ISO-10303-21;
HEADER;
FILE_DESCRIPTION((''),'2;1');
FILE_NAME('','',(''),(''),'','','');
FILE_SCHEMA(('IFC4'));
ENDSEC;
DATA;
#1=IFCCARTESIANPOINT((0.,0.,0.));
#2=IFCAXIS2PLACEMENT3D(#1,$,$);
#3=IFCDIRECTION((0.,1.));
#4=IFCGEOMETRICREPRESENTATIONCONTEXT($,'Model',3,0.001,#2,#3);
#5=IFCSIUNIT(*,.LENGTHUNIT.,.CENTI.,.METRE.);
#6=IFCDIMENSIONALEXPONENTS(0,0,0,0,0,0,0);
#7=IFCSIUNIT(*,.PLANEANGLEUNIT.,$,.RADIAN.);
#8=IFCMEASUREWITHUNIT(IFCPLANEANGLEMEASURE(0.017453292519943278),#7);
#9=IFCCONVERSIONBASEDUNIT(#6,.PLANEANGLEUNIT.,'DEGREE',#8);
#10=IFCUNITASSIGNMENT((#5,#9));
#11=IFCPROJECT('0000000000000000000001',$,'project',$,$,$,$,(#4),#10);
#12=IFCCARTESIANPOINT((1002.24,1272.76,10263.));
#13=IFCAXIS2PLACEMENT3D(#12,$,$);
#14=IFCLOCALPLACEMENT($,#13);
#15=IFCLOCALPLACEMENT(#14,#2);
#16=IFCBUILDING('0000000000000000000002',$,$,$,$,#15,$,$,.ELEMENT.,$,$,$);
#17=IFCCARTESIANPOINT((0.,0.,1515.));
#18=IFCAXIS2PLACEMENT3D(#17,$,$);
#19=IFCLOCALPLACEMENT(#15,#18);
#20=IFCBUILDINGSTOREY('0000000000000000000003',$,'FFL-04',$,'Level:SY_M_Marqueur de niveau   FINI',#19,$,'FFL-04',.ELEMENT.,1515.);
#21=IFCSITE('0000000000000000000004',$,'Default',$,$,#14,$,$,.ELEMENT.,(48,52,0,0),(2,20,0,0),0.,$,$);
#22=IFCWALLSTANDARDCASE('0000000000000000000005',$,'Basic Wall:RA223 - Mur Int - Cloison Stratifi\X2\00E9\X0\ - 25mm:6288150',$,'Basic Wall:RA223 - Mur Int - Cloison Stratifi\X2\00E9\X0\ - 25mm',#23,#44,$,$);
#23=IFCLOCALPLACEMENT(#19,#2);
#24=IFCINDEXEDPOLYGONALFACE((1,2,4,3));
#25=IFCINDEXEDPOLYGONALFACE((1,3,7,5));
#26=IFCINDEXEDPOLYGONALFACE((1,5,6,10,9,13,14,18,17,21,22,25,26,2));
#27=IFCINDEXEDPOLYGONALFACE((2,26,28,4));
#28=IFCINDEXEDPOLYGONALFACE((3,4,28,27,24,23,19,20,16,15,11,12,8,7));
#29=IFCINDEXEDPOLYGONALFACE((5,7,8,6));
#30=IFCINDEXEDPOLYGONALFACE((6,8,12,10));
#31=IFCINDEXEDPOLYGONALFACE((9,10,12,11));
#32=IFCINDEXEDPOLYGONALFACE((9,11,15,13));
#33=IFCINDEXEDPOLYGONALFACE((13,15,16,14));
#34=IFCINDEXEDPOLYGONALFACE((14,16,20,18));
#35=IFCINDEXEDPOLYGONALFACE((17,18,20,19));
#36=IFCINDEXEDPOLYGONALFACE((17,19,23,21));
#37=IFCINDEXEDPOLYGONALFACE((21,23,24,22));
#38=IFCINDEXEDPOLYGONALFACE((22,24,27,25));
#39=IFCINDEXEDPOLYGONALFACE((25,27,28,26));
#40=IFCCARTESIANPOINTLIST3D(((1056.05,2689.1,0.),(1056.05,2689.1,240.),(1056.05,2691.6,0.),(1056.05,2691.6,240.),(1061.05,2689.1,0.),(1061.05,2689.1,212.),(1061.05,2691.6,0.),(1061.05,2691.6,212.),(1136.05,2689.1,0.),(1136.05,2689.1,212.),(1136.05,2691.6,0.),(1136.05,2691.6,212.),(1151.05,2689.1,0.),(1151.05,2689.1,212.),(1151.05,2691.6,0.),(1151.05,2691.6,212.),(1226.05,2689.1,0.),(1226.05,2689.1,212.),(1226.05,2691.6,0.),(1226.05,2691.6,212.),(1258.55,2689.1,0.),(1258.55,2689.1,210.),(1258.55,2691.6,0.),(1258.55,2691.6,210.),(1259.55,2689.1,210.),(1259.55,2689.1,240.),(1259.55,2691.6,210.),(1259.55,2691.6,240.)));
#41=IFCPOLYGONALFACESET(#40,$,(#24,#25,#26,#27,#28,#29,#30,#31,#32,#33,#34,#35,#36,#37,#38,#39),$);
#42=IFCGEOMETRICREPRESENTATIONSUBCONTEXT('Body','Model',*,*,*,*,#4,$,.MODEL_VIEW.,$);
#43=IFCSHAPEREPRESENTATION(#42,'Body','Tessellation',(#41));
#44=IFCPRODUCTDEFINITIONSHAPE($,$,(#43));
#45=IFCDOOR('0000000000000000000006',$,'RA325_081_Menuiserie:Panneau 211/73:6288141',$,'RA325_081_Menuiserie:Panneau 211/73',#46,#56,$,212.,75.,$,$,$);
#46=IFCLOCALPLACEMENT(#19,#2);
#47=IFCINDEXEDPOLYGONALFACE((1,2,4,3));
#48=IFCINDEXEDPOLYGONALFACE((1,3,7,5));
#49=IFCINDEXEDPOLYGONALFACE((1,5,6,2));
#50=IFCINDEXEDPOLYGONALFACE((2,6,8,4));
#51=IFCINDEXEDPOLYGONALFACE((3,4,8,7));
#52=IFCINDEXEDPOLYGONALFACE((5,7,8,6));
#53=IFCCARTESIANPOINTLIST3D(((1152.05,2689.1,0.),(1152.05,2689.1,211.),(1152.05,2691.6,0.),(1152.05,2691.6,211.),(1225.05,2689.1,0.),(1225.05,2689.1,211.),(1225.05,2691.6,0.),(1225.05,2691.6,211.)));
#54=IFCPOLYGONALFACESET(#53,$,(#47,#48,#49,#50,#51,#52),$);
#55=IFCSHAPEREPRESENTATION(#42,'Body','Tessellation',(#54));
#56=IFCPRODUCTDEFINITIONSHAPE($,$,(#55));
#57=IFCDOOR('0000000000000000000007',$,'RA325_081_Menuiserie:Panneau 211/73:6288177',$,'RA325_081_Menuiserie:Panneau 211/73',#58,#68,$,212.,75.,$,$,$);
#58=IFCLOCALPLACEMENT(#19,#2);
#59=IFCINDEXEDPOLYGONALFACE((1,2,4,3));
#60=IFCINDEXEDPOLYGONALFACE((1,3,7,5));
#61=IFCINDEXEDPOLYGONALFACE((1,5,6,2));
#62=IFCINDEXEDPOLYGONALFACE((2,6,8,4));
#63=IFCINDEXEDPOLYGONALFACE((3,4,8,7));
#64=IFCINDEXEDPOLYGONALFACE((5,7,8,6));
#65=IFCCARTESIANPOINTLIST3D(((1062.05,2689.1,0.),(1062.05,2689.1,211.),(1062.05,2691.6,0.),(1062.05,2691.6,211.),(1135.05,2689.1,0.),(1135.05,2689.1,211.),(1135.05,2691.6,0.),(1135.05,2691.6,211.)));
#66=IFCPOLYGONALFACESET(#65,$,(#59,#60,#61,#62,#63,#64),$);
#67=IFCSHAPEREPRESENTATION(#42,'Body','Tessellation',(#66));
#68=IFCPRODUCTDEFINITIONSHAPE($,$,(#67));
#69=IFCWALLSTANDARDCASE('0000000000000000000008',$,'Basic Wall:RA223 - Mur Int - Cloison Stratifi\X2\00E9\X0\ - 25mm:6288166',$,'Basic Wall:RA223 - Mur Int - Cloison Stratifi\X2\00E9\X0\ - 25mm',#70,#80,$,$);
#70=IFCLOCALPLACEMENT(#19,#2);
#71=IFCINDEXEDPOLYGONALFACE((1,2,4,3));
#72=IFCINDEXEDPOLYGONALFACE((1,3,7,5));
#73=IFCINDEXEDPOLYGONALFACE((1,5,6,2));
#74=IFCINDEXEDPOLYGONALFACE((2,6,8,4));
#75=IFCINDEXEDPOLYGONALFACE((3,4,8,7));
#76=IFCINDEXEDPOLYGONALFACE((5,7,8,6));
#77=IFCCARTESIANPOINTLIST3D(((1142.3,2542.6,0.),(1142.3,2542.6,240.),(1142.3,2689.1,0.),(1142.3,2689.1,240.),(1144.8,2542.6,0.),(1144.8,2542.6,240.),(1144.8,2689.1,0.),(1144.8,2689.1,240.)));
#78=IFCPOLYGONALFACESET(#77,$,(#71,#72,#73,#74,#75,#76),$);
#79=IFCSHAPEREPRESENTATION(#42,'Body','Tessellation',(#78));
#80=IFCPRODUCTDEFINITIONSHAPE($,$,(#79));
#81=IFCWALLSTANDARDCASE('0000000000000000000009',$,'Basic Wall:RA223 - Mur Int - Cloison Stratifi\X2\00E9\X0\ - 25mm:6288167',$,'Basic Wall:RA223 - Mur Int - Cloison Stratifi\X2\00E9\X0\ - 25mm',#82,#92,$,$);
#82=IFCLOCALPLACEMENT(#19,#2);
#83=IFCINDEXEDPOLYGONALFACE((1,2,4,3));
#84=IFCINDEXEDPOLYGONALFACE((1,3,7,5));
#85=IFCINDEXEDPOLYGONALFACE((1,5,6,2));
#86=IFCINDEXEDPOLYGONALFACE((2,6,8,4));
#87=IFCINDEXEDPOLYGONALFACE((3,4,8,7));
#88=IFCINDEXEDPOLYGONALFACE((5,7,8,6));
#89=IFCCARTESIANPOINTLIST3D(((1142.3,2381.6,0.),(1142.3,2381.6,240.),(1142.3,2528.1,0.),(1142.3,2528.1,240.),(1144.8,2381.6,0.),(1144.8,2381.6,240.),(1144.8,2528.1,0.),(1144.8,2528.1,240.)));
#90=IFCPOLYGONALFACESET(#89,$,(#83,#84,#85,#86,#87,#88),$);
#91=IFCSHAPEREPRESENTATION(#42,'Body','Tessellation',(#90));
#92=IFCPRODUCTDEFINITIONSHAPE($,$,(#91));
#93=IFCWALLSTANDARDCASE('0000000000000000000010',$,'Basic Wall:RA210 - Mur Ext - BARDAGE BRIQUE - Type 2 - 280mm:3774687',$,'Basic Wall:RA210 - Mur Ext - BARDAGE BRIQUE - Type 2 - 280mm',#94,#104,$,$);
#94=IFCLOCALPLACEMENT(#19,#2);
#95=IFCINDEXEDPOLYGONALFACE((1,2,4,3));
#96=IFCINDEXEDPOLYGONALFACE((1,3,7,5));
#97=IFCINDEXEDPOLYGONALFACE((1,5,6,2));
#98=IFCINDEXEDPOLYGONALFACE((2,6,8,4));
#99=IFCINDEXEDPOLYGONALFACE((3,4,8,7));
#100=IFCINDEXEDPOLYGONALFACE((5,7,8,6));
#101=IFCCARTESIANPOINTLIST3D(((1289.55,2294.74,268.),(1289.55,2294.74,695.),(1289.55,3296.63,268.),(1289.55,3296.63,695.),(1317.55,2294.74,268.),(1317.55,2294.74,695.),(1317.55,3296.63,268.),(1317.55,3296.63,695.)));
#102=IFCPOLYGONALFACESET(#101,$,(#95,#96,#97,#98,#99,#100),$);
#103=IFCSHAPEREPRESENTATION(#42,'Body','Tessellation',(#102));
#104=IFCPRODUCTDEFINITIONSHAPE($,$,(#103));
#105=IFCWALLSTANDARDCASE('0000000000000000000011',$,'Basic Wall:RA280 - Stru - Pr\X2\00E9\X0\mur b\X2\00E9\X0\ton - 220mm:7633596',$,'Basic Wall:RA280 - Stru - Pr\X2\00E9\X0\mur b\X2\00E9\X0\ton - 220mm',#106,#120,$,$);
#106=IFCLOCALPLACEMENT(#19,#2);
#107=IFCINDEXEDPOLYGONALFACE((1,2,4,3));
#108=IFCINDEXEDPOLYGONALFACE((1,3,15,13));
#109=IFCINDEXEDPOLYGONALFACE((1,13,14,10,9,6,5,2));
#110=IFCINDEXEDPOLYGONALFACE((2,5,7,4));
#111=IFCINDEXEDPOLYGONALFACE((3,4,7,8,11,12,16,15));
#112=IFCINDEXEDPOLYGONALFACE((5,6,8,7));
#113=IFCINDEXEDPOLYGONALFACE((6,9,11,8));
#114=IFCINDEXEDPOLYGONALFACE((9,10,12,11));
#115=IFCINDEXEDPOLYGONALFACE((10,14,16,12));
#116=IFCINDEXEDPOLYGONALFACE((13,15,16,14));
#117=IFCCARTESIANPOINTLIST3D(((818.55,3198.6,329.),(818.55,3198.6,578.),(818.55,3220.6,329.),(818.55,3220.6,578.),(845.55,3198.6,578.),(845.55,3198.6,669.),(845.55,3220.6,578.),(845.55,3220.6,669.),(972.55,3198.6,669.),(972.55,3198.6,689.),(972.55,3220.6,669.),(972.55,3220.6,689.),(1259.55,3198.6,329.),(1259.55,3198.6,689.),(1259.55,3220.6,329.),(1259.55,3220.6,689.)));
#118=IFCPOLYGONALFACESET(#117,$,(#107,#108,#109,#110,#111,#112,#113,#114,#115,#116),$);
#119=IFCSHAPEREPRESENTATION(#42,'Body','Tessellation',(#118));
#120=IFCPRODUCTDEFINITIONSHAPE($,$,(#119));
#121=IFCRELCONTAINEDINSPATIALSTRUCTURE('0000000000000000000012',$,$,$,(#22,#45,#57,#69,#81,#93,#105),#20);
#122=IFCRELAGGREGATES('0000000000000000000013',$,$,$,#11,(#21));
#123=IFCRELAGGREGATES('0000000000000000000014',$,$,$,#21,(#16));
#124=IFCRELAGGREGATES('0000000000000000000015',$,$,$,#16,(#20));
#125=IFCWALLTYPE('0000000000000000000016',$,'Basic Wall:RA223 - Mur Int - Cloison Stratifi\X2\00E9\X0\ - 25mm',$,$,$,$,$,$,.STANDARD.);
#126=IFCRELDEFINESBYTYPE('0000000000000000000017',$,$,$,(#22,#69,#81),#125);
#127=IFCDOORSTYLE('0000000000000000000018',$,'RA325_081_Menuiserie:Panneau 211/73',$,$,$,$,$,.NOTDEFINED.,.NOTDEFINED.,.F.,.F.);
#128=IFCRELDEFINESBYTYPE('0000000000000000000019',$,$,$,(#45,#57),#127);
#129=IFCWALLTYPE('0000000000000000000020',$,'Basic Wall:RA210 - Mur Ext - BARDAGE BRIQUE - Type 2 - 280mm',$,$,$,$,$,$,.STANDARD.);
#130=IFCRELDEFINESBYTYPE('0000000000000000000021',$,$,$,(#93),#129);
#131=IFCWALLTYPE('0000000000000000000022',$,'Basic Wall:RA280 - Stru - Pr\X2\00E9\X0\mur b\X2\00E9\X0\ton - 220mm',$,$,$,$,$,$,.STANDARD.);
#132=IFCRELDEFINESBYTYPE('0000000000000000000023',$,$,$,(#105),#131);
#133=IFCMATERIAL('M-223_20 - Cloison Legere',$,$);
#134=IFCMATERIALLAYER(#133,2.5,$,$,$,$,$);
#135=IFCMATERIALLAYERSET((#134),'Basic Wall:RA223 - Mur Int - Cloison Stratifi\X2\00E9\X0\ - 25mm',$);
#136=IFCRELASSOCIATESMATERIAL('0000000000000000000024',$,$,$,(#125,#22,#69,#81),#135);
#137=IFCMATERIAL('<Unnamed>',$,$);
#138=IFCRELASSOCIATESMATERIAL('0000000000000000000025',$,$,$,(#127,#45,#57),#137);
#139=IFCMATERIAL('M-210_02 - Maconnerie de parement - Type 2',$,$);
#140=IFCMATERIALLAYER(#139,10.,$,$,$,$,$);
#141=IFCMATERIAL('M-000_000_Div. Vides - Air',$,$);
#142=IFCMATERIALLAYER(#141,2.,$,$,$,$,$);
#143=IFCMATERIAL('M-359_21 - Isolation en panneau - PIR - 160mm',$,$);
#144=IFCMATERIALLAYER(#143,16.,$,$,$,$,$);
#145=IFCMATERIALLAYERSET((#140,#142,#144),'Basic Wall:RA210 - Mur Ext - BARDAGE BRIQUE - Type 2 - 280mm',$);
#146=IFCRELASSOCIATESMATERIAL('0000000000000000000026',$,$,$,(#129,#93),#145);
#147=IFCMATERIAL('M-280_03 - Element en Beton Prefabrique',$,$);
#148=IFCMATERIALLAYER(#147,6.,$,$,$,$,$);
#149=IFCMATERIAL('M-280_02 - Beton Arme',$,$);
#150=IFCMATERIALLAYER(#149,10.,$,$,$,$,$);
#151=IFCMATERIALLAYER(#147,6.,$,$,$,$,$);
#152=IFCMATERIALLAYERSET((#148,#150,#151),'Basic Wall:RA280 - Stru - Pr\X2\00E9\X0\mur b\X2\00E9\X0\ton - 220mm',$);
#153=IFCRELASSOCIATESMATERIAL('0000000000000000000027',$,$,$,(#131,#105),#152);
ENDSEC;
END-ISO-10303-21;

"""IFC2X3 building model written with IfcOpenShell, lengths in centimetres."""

from ifc_helpers import new_model, entity, si_unit, converted_unit, direction, frame, frame_2d, origin, place, context, subcontext, project, spatial, polyline, rectangle, extrude, clip, bounded_halfspace, source, transform, mapped, material, layer, layer_set, layer_usage, type_object, type_shapes, element, fill, save


model = new_model("IFC2X3")

# Units and contexts
model_context = context("Model", 3, precision=0.001, world=origin(), true_north=direction((0.0, 1.0)))
body_context = subcontext(model_context, "Body", "Model", "MODEL_VIEW")
ifc_project = project(units=[si_unit("LENGTHUNIT", "METRE", prefix="CENTI"), converted_unit("PLANEANGLEUNIT", "DEGREE", entity("IfcPlaneAngleMeasure", 0.017453292519943278), si_unit("PLANEANGLEUNIT", "RADIAN"), dimensions=[0, 0, 0, 0, 0, 0, 0])], contexts=[model_context])

# Site, building, storey
site_placement = place(None, frame((1002.24, 1272.76, 10263.0)))
site = spatial("IfcSite", under=ifc_project, at=site_placement, Name="Default", CompositionType="ELEMENT", RefLatitude=(48, 52, 0, 0), RefLongitude=(2, 20, 0, 0), RefElevation=0.0)
building_placement = place(site_placement, origin())
building = spatial("IfcBuilding", under=site, at=building_placement, CompositionType="ELEMENT")
storey_placement = place(building_placement, frame((0.0, 0.0, 1515.0)))
storey = spatial("IfcBuildingStorey", under=building, at=storey_placement, Name="FFL-04", ObjectType="Level:SY_M_Marqueur de niveau   FINI", LongName="FFL-04", CompositionType="ELEMENT", Elevation=1515.0)

# Shared definitions
ifc_material_1 = material(Name="M-280_02 - Beton Arme")

# Shared definitions
ifc_material_2 = material(Name="M-223_20 - Cloison Legere")
ifc_material_3 = material(Name="M-000_000_Div. Vides - Air")

# Wall, openings, doors
ifc_layer_1 = layer(ifc_material_2, 2.5)
ifc_layer_set_1 = layer_set([ifc_layer_1], Name="Basic Wall:RA223 - Mur Int - Cloison Stratifié - 25mm")
ifc_layer_usage_1 = layer_usage(ifc_layer_set_1, "AXIS2", "NEGATIVE", 1.25)
wall_type_1 = type_object("IfcWallType", Name="Basic Wall:RA223 - Mur Int - Cloison Stratifié - 25mm", PredefinedType="STANDARD", material=ifc_layer_set_1)
wall_1_placement = place(storey_placement, frame((1056.05, 2690.35, 0.0)))
wall_1 = element("IfcWallStandardCase", 1, at=wall_1_placement, inside=storey, type_object=wall_type_1, material=ifc_layer_usage_1, Name="Basic Wall:RA223 - Mur Int - Cloison Stratifié - 25mm:6288150", ObjectType="Basic Wall:RA223 - Mur Int - Cloison Stratifié - 25mm", context=body_context, shape_type="Clipping", body=[
    clip(clip(extrude(rectangle(XDim=203.49, YDim=2.5, at=frame_2d((101.75, 0.0), x_axis=(-1.0, 0.0))), origin(), (0.0, 0.0, 1.0), 240.0), bounded_halfspace(frame((202.49, 1.25, 210.0), z_axis=(-1.0, 0.0, 0.0), x_axis=(0.0, -1.0, 0.0)), True, frame((202.49, 1.25, 210.0), z_axis=(-1.0, 0.0, 0.0), x_axis=(0.0, -1.0, 0.0)), polyline([(0.0, 0.0), (0.0, -210.0), (2.5, -210.0), (2.5, 0.0), (0.0, 0.0)]))), bounded_halfspace(frame((202.49, -1.25, 210.0), z_axis=(0.0, 0.0, 1.0), x_axis=(-1.0, 0.0, 0.0)), True, frame((202.49, -1.25, 210.0), z_axis=(0.0, 0.0, 1.0), x_axis=(-1.0, 0.0, 0.0)), polyline([(0.0, 0.0), (-1.0, 0.0), (-1.0, -2.5), (0.0, -2.5), (0.0, 0.0)]))),
])
opening_1_placement = place(wall_1_placement, frame((-1056.05, -2690.35, 0.0)))
opening_1 = element("IfcOpeningElement", 2, at=opening_1_placement, cuts=wall_1, ObjectType="Opening", context=body_context, shape_type="SweptSolid", body=[
    extrude(rectangle(XDim=212.0, YDim=75.0, at=frame_2d((0.0, 0.0), x_axis=(1.0, 0.0))), frame((1188.55, 2689.1, 106.0), z_axis=(0.0, 1.0, 0.0), x_axis=(0.0, 0.0, -1.0)), (0.0, 0.0, 1.0), 2.5),
])
opening_2_placement = place(wall_1_placement, frame((-1056.05, -2690.35, 0.0)))
opening_2 = element("IfcOpeningElement", 3, at=opening_2_placement, cuts=wall_1, ObjectType="Opening", context=body_context, shape_type="SweptSolid", body=[
    extrude(rectangle(XDim=212.0, YDim=75.0, at=frame_2d((0.0, 0.0), x_axis=(1.0, 0.0))), frame((1098.55, 2689.1, 106.0), z_axis=(0.0, 1.0, 0.0), x_axis=(0.0, 0.0, -1.0)), (0.0, 0.0, 1.0), 2.5),
])
ifc_material_4 = material(Name="<Unnamed>")
door_style = type_object("IfcDoorStyle", Name="RA325_081_Menuiserie:Panneau 211/73", ConstructionType="NOTDEFINED", OperationType="NOTDEFINED", ParameterTakesPrecedence=False, Sizeable=False, material=ifc_material_4)
shared_shape = source(origin(), body_context, "Body", "SweptSolid", [
    extrude(rectangle(XDim=73.0, YDim=2.5, at=frame_2d((0.0, 0.0), x_axis=(1.0, 0.0))), frame((37.5, 1.25, 0.0), z_axis=(0.0, 0.0, 1.0), x_axis=(-1.0, 0.0, 0.0)), (0.0, 0.0, 1.0), 211.0),
])
type_shapes(door_style, [shared_shape])
door_1_placement = place(opening_1_placement, frame((1151.05, 2689.1, 0.0)))
door_1 = element("IfcDoor", 4, at=door_1_placement, inside=storey, type_object=door_style, material=ifc_material_4, Name="RA325_081_Menuiserie:Panneau 211/73:6288141", ObjectType="RA325_081_Menuiserie:Panneau 211/73", OverallHeight=212.0, OverallWidth=75.0, context=body_context, shape_type="MappedRepresentation", body=[
    mapped(shared_shape, transform((0.0, 0.0, 0.0), scale=1.0)),
])
fill(opening_1, door_1)
door_2_placement = place(opening_2_placement, frame((1061.05, 2689.1, 0.0)))
door_2 = element("IfcDoor", 5, at=door_2_placement, inside=storey, type_object=door_style, material=ifc_material_4, Name="RA325_081_Menuiserie:Panneau 211/73:6288177", ObjectType="RA325_081_Menuiserie:Panneau 211/73", OverallHeight=212.0, OverallWidth=75.0, context=body_context, shape_type="MappedRepresentation", body=[
    mapped(shared_shape, transform((0.0, 0.0, 0.0), scale=1.0)),
])
fill(opening_2, door_2)

# Walls
ifc_layer_usage_2 = layer_usage(ifc_layer_set_1, "AXIS2", "NEGATIVE", 1.25)
wall_2_placement = place(storey_placement, frame((1143.55, 2542.6, 0.0), z_axis=(0.0, 0.0, 1.0), x_axis=(0.0, 1.0, 0.0)))
element("IfcWallStandardCase", 6, at=wall_2_placement, inside=storey, type_object=wall_type_1, material=ifc_layer_usage_2, Name="Basic Wall:RA223 - Mur Int - Cloison Stratifié - 25mm:6288166", ObjectType="Basic Wall:RA223 - Mur Int - Cloison Stratifié - 25mm", context=body_context, shape_type="SweptSolid", body=[
    extrude(rectangle(XDim=146.5, YDim=2.5, at=frame_2d((73.25, 0.0), x_axis=(-1.0, 0.0))), origin(), (0.0, 0.0, 1.0), 240.0),
])
ifc_layer_usage_3 = layer_usage(ifc_layer_set_1, "AXIS2", "POSITIVE", -1.25)
wall_3_placement = place(storey_placement, frame((1143.55, 2528.1, 0.0), z_axis=(0.0, 0.0, 1.0), x_axis=(0.0, -1.0, 0.0)))
element("IfcWallStandardCase", 7, at=wall_3_placement, inside=storey, type_object=wall_type_1, material=ifc_layer_usage_3, Name="Basic Wall:RA223 - Mur Int - Cloison Stratifié - 25mm:6288167", ObjectType="Basic Wall:RA223 - Mur Int - Cloison Stratifié - 25mm", context=body_context, shape_type="SweptSolid", body=[
    extrude(rectangle(XDim=146.5, YDim=2.5, at=frame_2d((73.25, 0.0), x_axis=(-1.0, 0.0))), origin(), (0.0, 0.0, 1.0), 240.0),
])
ifc_material_5 = material(Name="M-210_02 - Maconnerie de parement - Type 2")
ifc_layer_2 = layer(ifc_material_5, 10.0)
ifc_layer_3 = layer(ifc_material_3, 2.0)
ifc_material_6 = material(Name="M-359_21 - Isolation en panneau - PIR - 160mm")
ifc_layer_4 = layer(ifc_material_6, 16.0)
ifc_layer_set_2 = layer_set([ifc_layer_2, ifc_layer_3, ifc_layer_4], Name="Basic Wall:RA210 - Mur Ext - BARDAGE BRIQUE - Type 2 - 280mm")
ifc_layer_usage_4 = layer_usage(ifc_layer_set_2, "AXIS2", "NEGATIVE", 14.0)
wall_type_2 = type_object("IfcWallType", Name="Basic Wall:RA210 - Mur Ext - BARDAGE BRIQUE - Type 2 - 280mm", PredefinedType="STANDARD", material=ifc_layer_set_2)
wall_4_placement = place(storey_placement, frame((1303.55, 3296.63, 268.0), z_axis=(0.0, 0.0, 1.0), x_axis=(0.0, -1.0, 0.0)))
element("IfcWallStandardCase", 8, at=wall_4_placement, inside=storey, type_object=wall_type_2, material=ifc_layer_usage_4, Name="Basic Wall:RA210 - Mur Ext - BARDAGE BRIQUE - Type 2 - 280mm:3774687", ObjectType="Basic Wall:RA210 - Mur Ext - BARDAGE BRIQUE - Type 2 - 280mm", context=body_context, shape_type="SweptSolid", body=[
    extrude(rectangle(XDim=1001.88, YDim=28.0, at=frame_2d((500.94, 0.0), x_axis=(-1.0, 0.0))), origin(), (0.0, 0.0, 1.0), 427.0),
])
ifc_material_7 = material(Name="M-280_03 - Element en Beton Prefabrique")
ifc_layer_5 = layer(ifc_material_7, 6.0)
ifc_layer_6 = layer(ifc_material_1, 10.0)
ifc_layer_7 = layer(ifc_material_7, 6.0)
ifc_layer_set_3 = layer_set([ifc_layer_5, ifc_layer_6, ifc_layer_7], Name="Basic Wall:RA280 - Stru - Prémur béton - 220mm")
ifc_layer_usage_5 = layer_usage(ifc_layer_set_3, "AXIS2", "POSITIVE", -11.0)
wall_type_3 = type_object("IfcWallType", Name="Basic Wall:RA280 - Stru - Prémur béton - 220mm", PredefinedType="STANDARD", material=ifc_layer_set_3)
wall_5_placement = place(storey_placement, frame((1259.55, 3209.6, 329.0), z_axis=(0.0, 0.0, 1.0), x_axis=(-1.0, 0.0, 0.0)))
element("IfcWallStandardCase", 9, at=wall_5_placement, inside=storey, type_object=wall_type_3, material=ifc_layer_usage_5, Name="Basic Wall:RA280 - Stru - Prémur béton - 220mm:7633596", ObjectType="Basic Wall:RA280 - Stru - Prémur béton - 220mm", context=body_context, shape_type="Clipping", body=[
    clip(clip(clip(clip(extrude(rectangle(XDim=440.99, YDim=22.0, at=frame_2d((220.5, 0.0), x_axis=(-1.0, 0.0))), origin(), (0.0, 0.0, 1.0), 360.0), bounded_halfspace(frame((413.99, -11.0, 249.0), z_axis=(-1.0, 0.0, 0.0), x_axis=(0.0, 0.0, 1.0)), True, frame((413.99, -11.0, 249.0), z_axis=(-1.0, 0.0, 0.0), x_axis=(0.0, 0.0, 1.0)), polyline([(0.0, 0.0), (91.0, 0.0), (91.0, 22.0), (0.0, 22.0), (0.0, 0.0)]))), bounded_halfspace(frame((287.0, 11.0, 340.0), z_axis=(0.0, 0.0, -1.0), x_axis=(-1.0, 0.0, 0.0)), True, frame((287.0, 11.0, 340.0), z_axis=(0.0, 0.0, -1.0), x_axis=(-1.0, 0.0, 0.0)), polyline([(0.0, 0.0), (-126.99, 0.0), (-126.99, -22.0), (0.0, -22.0), (0.0, 0.0)]))), bounded_halfspace(frame((287.0, -11.0, 340.0), z_axis=(-1.0, 0.0, 0.0), x_axis=(0.0, 0.0, 1.0)), True, frame((287.0, -11.0, 340.0), z_axis=(-1.0, 0.0, 0.0), x_axis=(0.0, 0.0, 1.0)), polyline([(0.0, 0.0), (20.0, 0.0), (20.0, 22.0), (0.0, 22.0), (0.0, 0.0)]))), bounded_halfspace(frame((413.99, 11.0, 249.0), z_axis=(0.0, 0.0, 1.0), x_axis=(-1.0, 0.0, 0.0)), False, frame((413.99, 11.0, 249.0), z_axis=(0.0, 0.0, 1.0), x_axis=(-1.0, 0.0, 0.0)), polyline([(0.0, 0.0), (0.0, 22.0), (-27.0, 22.0), (-27.0, 0.0), (0.0, 0.0)]))),
])

save(model, "model.ifc")
